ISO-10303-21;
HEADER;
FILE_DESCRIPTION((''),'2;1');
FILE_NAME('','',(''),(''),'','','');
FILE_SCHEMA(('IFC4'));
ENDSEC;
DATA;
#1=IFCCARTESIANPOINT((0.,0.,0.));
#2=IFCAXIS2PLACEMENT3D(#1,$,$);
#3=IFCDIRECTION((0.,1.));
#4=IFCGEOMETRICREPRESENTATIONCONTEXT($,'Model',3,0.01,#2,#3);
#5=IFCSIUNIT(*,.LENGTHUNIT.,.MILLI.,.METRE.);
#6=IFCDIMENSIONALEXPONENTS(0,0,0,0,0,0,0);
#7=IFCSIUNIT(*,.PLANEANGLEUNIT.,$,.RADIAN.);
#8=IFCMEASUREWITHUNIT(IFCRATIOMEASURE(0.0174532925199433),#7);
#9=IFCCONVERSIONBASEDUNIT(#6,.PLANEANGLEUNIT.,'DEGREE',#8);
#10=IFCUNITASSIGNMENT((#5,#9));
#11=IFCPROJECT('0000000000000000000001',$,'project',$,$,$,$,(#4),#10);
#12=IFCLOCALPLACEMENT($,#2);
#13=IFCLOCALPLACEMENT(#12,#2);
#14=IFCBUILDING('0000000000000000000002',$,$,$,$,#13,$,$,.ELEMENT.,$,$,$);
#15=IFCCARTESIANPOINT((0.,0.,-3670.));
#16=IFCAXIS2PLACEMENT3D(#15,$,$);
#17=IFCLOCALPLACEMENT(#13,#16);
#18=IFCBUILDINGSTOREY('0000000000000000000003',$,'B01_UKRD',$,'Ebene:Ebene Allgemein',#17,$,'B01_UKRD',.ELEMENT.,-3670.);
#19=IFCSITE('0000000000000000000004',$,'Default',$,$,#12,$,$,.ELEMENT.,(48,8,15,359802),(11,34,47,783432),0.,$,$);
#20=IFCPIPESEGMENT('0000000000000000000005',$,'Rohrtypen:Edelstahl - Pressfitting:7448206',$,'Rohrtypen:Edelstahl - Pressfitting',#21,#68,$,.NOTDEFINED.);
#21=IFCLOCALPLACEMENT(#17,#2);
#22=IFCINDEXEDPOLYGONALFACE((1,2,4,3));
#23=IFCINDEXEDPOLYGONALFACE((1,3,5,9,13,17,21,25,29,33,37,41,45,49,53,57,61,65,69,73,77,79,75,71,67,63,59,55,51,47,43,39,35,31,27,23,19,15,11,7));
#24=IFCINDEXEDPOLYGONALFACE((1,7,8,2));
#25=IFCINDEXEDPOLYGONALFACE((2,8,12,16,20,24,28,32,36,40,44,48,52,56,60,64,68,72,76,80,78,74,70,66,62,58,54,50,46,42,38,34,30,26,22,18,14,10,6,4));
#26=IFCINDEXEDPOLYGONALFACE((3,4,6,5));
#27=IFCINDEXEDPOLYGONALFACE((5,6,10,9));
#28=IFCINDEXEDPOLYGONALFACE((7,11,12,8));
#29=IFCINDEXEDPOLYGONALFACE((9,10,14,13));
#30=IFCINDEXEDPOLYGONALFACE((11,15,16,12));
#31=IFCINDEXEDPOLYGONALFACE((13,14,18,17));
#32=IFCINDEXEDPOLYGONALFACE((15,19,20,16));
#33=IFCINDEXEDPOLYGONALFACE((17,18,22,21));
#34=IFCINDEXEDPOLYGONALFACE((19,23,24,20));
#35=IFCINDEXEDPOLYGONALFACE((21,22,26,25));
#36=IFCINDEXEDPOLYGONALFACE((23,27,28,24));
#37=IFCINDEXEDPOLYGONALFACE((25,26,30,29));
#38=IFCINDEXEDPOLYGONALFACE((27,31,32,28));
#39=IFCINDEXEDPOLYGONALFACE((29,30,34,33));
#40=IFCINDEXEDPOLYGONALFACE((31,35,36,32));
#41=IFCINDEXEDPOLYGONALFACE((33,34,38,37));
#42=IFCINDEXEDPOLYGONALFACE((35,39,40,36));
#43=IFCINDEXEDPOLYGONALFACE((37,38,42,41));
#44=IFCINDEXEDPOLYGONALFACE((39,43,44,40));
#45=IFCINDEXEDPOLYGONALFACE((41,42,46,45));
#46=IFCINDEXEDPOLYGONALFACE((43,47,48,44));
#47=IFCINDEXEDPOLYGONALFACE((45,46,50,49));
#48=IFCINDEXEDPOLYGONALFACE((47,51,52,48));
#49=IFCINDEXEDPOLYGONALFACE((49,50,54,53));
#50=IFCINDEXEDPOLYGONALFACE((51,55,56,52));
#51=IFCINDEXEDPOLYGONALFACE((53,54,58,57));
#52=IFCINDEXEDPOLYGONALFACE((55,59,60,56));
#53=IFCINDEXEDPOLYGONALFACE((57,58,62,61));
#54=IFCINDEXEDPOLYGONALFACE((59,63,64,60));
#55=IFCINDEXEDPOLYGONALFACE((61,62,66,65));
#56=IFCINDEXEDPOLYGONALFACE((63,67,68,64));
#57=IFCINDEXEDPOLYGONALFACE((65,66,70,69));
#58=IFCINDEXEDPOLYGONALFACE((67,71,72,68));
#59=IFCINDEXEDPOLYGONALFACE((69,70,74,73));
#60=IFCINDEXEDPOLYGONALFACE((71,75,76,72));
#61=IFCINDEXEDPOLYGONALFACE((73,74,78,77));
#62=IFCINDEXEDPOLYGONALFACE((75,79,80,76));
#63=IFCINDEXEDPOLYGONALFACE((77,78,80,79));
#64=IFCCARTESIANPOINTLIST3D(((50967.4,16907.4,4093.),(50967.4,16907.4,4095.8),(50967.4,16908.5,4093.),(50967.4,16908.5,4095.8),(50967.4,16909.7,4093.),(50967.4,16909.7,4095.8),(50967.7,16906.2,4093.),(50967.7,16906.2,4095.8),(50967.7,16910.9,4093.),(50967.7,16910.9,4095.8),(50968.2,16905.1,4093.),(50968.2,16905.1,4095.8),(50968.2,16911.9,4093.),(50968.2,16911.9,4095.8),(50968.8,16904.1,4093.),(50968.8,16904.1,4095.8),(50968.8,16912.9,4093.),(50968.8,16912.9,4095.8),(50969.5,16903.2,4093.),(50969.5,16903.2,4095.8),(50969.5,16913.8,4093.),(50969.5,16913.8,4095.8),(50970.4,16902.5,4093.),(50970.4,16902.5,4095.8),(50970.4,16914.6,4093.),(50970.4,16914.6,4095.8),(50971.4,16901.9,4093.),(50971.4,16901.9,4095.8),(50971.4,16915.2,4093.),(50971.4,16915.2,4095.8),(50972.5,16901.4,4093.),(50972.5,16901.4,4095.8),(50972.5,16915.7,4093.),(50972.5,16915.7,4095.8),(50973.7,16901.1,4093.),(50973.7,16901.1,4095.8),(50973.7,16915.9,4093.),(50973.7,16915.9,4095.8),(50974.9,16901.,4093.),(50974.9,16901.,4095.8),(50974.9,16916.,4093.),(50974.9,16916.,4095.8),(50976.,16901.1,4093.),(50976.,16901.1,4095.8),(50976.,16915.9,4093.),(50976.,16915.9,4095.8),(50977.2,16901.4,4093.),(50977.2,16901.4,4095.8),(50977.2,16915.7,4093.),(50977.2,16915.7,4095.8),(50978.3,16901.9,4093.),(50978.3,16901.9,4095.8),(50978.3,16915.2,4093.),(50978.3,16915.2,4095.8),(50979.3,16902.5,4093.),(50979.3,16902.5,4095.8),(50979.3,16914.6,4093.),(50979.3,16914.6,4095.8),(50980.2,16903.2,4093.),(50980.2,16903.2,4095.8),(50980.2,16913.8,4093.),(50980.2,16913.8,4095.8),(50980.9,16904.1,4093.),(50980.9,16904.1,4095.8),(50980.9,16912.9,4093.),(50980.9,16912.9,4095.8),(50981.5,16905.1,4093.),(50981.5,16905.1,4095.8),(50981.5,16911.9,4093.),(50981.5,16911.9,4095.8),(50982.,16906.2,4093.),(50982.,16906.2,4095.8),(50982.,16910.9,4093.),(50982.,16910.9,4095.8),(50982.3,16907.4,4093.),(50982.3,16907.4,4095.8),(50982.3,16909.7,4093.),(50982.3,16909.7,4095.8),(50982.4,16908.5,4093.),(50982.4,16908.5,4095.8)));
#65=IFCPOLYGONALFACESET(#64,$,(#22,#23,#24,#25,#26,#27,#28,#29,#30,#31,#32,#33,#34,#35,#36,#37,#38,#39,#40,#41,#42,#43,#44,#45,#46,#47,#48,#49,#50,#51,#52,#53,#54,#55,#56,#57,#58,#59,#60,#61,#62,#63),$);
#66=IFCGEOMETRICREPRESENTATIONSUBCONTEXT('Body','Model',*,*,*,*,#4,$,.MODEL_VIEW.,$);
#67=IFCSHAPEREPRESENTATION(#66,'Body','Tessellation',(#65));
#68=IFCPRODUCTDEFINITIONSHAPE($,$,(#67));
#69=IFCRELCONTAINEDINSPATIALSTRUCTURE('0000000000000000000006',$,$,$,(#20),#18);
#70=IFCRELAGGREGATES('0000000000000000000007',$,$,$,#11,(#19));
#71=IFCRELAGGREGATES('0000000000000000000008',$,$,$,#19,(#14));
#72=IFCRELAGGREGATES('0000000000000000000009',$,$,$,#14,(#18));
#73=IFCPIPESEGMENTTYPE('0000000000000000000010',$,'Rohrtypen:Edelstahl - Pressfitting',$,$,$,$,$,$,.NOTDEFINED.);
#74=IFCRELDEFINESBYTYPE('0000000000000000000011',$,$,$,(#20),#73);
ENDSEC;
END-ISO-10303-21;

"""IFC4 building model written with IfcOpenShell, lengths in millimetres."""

from ifc_helpers import new_model, entity, si_unit, converted_unit, direction, frame, origin, place, context, subcontext, project, spatial, indexed_curve, outline, extrude, type_object, element, save


model = new_model("IFC4")

# Units and contexts
model_context = context("Model", 3, precision=0.01, world=origin(), true_north=direction((0.0, 1.0)))
body_context = subcontext(model_context, "Body", "Model", "MODEL_VIEW")
ifc_project = project(units=[si_unit("LENGTHUNIT", "METRE", prefix="MILLI"), converted_unit("PLANEANGLEUNIT", "DEGREE", entity("IfcRatioMeasure", 0.0174532925199433), si_unit("PLANEANGLEUNIT", "RADIAN"), dimensions=[0, 0, 0, 0, 0, 0, 0])], contexts=[model_context])

# Site, building, storey
site_placement = place(None, origin())
site = spatial("IfcSite", under=ifc_project, at=site_placement, Name="Default", CompositionType="ELEMENT", RefLatitude=(48, 8, 15, 359802), RefLongitude=(11, 34, 47, 783432), RefElevation=0.0)
building_placement = place(site_placement, origin())
building = spatial("IfcBuilding", under=site, at=building_placement, CompositionType="ELEMENT")
storey_placement = place(building_placement, frame((0.0, 0.0, -3670.0)))
storey = spatial("IfcBuildingStorey", under=building, at=storey_placement, Name="B01_UKRD", ObjectType="Ebene:Ebene Allgemein", LongName="B01_UKRD", CompositionType="ELEMENT", Elevation=-3670.0)

# Pipe segment
pipe_segment_type = type_object("IfcPipeSegmentType", Name="Rohrtypen:Edelstahl - Pressfitting", PredefinedType="NOTDEFINED")
pipe_segment_1_placement = place(storey_placement, origin())
element("IfcPipeSegment", 1, at=pipe_segment_1_placement, inside=storey, type_object=pipe_segment_type, Name="Rohrtypen:Edelstahl - Pressfitting:7448206", ObjectType="Rohrtypen:Edelstahl - Pressfitting", PredefinedType="NOTDEFINED", context=body_context, shape_type="SweptSolid", body=[
    extrude(outline(indexed_curve([(7.5, 0.0), (7.4, 1.2), (7.1, 2.3), (6.7, 3.4), (6.1, 4.4), (5.3, 5.3), (4.4, 6.1), (3.4, 6.7), (2.3, 7.1), (1.2, 7.4), (0.0, 7.5), (-1.2, 7.4), (-2.3, 7.1), (-3.4, 6.7), (-4.4, 6.1), (-5.3, 5.3), (-6.1, 4.4), (-6.7, 3.4), (-7.1, 2.3), (-7.4, 1.2), (-7.5, 0.0), (-7.4, -1.2), (-7.1, -2.3), (-6.7, -3.4), (-6.1, -4.4), (-5.3, -5.3), (-4.4, -6.1), (-3.4, -6.7), (-2.3, -7.1), (-1.2, -7.4), (0.0, -7.5), (1.2, -7.4), (2.3, -7.1), (3.4, -6.7), (4.4, -6.1), (5.3, -5.3), (6.1, -4.4), (6.7, -3.4), (7.1, -2.3), (7.4, -1.2), (7.5, 0.0)], self_intersect=False)), frame((50974.9, 16908.5, 4093.0), z_axis=(0.0, 0.0, 1.0), x_axis=(-1.0, 0.0, 0.0)), (0.0, 0.0, 1.0), 2.8),
])

save(model, "model.ifc")
